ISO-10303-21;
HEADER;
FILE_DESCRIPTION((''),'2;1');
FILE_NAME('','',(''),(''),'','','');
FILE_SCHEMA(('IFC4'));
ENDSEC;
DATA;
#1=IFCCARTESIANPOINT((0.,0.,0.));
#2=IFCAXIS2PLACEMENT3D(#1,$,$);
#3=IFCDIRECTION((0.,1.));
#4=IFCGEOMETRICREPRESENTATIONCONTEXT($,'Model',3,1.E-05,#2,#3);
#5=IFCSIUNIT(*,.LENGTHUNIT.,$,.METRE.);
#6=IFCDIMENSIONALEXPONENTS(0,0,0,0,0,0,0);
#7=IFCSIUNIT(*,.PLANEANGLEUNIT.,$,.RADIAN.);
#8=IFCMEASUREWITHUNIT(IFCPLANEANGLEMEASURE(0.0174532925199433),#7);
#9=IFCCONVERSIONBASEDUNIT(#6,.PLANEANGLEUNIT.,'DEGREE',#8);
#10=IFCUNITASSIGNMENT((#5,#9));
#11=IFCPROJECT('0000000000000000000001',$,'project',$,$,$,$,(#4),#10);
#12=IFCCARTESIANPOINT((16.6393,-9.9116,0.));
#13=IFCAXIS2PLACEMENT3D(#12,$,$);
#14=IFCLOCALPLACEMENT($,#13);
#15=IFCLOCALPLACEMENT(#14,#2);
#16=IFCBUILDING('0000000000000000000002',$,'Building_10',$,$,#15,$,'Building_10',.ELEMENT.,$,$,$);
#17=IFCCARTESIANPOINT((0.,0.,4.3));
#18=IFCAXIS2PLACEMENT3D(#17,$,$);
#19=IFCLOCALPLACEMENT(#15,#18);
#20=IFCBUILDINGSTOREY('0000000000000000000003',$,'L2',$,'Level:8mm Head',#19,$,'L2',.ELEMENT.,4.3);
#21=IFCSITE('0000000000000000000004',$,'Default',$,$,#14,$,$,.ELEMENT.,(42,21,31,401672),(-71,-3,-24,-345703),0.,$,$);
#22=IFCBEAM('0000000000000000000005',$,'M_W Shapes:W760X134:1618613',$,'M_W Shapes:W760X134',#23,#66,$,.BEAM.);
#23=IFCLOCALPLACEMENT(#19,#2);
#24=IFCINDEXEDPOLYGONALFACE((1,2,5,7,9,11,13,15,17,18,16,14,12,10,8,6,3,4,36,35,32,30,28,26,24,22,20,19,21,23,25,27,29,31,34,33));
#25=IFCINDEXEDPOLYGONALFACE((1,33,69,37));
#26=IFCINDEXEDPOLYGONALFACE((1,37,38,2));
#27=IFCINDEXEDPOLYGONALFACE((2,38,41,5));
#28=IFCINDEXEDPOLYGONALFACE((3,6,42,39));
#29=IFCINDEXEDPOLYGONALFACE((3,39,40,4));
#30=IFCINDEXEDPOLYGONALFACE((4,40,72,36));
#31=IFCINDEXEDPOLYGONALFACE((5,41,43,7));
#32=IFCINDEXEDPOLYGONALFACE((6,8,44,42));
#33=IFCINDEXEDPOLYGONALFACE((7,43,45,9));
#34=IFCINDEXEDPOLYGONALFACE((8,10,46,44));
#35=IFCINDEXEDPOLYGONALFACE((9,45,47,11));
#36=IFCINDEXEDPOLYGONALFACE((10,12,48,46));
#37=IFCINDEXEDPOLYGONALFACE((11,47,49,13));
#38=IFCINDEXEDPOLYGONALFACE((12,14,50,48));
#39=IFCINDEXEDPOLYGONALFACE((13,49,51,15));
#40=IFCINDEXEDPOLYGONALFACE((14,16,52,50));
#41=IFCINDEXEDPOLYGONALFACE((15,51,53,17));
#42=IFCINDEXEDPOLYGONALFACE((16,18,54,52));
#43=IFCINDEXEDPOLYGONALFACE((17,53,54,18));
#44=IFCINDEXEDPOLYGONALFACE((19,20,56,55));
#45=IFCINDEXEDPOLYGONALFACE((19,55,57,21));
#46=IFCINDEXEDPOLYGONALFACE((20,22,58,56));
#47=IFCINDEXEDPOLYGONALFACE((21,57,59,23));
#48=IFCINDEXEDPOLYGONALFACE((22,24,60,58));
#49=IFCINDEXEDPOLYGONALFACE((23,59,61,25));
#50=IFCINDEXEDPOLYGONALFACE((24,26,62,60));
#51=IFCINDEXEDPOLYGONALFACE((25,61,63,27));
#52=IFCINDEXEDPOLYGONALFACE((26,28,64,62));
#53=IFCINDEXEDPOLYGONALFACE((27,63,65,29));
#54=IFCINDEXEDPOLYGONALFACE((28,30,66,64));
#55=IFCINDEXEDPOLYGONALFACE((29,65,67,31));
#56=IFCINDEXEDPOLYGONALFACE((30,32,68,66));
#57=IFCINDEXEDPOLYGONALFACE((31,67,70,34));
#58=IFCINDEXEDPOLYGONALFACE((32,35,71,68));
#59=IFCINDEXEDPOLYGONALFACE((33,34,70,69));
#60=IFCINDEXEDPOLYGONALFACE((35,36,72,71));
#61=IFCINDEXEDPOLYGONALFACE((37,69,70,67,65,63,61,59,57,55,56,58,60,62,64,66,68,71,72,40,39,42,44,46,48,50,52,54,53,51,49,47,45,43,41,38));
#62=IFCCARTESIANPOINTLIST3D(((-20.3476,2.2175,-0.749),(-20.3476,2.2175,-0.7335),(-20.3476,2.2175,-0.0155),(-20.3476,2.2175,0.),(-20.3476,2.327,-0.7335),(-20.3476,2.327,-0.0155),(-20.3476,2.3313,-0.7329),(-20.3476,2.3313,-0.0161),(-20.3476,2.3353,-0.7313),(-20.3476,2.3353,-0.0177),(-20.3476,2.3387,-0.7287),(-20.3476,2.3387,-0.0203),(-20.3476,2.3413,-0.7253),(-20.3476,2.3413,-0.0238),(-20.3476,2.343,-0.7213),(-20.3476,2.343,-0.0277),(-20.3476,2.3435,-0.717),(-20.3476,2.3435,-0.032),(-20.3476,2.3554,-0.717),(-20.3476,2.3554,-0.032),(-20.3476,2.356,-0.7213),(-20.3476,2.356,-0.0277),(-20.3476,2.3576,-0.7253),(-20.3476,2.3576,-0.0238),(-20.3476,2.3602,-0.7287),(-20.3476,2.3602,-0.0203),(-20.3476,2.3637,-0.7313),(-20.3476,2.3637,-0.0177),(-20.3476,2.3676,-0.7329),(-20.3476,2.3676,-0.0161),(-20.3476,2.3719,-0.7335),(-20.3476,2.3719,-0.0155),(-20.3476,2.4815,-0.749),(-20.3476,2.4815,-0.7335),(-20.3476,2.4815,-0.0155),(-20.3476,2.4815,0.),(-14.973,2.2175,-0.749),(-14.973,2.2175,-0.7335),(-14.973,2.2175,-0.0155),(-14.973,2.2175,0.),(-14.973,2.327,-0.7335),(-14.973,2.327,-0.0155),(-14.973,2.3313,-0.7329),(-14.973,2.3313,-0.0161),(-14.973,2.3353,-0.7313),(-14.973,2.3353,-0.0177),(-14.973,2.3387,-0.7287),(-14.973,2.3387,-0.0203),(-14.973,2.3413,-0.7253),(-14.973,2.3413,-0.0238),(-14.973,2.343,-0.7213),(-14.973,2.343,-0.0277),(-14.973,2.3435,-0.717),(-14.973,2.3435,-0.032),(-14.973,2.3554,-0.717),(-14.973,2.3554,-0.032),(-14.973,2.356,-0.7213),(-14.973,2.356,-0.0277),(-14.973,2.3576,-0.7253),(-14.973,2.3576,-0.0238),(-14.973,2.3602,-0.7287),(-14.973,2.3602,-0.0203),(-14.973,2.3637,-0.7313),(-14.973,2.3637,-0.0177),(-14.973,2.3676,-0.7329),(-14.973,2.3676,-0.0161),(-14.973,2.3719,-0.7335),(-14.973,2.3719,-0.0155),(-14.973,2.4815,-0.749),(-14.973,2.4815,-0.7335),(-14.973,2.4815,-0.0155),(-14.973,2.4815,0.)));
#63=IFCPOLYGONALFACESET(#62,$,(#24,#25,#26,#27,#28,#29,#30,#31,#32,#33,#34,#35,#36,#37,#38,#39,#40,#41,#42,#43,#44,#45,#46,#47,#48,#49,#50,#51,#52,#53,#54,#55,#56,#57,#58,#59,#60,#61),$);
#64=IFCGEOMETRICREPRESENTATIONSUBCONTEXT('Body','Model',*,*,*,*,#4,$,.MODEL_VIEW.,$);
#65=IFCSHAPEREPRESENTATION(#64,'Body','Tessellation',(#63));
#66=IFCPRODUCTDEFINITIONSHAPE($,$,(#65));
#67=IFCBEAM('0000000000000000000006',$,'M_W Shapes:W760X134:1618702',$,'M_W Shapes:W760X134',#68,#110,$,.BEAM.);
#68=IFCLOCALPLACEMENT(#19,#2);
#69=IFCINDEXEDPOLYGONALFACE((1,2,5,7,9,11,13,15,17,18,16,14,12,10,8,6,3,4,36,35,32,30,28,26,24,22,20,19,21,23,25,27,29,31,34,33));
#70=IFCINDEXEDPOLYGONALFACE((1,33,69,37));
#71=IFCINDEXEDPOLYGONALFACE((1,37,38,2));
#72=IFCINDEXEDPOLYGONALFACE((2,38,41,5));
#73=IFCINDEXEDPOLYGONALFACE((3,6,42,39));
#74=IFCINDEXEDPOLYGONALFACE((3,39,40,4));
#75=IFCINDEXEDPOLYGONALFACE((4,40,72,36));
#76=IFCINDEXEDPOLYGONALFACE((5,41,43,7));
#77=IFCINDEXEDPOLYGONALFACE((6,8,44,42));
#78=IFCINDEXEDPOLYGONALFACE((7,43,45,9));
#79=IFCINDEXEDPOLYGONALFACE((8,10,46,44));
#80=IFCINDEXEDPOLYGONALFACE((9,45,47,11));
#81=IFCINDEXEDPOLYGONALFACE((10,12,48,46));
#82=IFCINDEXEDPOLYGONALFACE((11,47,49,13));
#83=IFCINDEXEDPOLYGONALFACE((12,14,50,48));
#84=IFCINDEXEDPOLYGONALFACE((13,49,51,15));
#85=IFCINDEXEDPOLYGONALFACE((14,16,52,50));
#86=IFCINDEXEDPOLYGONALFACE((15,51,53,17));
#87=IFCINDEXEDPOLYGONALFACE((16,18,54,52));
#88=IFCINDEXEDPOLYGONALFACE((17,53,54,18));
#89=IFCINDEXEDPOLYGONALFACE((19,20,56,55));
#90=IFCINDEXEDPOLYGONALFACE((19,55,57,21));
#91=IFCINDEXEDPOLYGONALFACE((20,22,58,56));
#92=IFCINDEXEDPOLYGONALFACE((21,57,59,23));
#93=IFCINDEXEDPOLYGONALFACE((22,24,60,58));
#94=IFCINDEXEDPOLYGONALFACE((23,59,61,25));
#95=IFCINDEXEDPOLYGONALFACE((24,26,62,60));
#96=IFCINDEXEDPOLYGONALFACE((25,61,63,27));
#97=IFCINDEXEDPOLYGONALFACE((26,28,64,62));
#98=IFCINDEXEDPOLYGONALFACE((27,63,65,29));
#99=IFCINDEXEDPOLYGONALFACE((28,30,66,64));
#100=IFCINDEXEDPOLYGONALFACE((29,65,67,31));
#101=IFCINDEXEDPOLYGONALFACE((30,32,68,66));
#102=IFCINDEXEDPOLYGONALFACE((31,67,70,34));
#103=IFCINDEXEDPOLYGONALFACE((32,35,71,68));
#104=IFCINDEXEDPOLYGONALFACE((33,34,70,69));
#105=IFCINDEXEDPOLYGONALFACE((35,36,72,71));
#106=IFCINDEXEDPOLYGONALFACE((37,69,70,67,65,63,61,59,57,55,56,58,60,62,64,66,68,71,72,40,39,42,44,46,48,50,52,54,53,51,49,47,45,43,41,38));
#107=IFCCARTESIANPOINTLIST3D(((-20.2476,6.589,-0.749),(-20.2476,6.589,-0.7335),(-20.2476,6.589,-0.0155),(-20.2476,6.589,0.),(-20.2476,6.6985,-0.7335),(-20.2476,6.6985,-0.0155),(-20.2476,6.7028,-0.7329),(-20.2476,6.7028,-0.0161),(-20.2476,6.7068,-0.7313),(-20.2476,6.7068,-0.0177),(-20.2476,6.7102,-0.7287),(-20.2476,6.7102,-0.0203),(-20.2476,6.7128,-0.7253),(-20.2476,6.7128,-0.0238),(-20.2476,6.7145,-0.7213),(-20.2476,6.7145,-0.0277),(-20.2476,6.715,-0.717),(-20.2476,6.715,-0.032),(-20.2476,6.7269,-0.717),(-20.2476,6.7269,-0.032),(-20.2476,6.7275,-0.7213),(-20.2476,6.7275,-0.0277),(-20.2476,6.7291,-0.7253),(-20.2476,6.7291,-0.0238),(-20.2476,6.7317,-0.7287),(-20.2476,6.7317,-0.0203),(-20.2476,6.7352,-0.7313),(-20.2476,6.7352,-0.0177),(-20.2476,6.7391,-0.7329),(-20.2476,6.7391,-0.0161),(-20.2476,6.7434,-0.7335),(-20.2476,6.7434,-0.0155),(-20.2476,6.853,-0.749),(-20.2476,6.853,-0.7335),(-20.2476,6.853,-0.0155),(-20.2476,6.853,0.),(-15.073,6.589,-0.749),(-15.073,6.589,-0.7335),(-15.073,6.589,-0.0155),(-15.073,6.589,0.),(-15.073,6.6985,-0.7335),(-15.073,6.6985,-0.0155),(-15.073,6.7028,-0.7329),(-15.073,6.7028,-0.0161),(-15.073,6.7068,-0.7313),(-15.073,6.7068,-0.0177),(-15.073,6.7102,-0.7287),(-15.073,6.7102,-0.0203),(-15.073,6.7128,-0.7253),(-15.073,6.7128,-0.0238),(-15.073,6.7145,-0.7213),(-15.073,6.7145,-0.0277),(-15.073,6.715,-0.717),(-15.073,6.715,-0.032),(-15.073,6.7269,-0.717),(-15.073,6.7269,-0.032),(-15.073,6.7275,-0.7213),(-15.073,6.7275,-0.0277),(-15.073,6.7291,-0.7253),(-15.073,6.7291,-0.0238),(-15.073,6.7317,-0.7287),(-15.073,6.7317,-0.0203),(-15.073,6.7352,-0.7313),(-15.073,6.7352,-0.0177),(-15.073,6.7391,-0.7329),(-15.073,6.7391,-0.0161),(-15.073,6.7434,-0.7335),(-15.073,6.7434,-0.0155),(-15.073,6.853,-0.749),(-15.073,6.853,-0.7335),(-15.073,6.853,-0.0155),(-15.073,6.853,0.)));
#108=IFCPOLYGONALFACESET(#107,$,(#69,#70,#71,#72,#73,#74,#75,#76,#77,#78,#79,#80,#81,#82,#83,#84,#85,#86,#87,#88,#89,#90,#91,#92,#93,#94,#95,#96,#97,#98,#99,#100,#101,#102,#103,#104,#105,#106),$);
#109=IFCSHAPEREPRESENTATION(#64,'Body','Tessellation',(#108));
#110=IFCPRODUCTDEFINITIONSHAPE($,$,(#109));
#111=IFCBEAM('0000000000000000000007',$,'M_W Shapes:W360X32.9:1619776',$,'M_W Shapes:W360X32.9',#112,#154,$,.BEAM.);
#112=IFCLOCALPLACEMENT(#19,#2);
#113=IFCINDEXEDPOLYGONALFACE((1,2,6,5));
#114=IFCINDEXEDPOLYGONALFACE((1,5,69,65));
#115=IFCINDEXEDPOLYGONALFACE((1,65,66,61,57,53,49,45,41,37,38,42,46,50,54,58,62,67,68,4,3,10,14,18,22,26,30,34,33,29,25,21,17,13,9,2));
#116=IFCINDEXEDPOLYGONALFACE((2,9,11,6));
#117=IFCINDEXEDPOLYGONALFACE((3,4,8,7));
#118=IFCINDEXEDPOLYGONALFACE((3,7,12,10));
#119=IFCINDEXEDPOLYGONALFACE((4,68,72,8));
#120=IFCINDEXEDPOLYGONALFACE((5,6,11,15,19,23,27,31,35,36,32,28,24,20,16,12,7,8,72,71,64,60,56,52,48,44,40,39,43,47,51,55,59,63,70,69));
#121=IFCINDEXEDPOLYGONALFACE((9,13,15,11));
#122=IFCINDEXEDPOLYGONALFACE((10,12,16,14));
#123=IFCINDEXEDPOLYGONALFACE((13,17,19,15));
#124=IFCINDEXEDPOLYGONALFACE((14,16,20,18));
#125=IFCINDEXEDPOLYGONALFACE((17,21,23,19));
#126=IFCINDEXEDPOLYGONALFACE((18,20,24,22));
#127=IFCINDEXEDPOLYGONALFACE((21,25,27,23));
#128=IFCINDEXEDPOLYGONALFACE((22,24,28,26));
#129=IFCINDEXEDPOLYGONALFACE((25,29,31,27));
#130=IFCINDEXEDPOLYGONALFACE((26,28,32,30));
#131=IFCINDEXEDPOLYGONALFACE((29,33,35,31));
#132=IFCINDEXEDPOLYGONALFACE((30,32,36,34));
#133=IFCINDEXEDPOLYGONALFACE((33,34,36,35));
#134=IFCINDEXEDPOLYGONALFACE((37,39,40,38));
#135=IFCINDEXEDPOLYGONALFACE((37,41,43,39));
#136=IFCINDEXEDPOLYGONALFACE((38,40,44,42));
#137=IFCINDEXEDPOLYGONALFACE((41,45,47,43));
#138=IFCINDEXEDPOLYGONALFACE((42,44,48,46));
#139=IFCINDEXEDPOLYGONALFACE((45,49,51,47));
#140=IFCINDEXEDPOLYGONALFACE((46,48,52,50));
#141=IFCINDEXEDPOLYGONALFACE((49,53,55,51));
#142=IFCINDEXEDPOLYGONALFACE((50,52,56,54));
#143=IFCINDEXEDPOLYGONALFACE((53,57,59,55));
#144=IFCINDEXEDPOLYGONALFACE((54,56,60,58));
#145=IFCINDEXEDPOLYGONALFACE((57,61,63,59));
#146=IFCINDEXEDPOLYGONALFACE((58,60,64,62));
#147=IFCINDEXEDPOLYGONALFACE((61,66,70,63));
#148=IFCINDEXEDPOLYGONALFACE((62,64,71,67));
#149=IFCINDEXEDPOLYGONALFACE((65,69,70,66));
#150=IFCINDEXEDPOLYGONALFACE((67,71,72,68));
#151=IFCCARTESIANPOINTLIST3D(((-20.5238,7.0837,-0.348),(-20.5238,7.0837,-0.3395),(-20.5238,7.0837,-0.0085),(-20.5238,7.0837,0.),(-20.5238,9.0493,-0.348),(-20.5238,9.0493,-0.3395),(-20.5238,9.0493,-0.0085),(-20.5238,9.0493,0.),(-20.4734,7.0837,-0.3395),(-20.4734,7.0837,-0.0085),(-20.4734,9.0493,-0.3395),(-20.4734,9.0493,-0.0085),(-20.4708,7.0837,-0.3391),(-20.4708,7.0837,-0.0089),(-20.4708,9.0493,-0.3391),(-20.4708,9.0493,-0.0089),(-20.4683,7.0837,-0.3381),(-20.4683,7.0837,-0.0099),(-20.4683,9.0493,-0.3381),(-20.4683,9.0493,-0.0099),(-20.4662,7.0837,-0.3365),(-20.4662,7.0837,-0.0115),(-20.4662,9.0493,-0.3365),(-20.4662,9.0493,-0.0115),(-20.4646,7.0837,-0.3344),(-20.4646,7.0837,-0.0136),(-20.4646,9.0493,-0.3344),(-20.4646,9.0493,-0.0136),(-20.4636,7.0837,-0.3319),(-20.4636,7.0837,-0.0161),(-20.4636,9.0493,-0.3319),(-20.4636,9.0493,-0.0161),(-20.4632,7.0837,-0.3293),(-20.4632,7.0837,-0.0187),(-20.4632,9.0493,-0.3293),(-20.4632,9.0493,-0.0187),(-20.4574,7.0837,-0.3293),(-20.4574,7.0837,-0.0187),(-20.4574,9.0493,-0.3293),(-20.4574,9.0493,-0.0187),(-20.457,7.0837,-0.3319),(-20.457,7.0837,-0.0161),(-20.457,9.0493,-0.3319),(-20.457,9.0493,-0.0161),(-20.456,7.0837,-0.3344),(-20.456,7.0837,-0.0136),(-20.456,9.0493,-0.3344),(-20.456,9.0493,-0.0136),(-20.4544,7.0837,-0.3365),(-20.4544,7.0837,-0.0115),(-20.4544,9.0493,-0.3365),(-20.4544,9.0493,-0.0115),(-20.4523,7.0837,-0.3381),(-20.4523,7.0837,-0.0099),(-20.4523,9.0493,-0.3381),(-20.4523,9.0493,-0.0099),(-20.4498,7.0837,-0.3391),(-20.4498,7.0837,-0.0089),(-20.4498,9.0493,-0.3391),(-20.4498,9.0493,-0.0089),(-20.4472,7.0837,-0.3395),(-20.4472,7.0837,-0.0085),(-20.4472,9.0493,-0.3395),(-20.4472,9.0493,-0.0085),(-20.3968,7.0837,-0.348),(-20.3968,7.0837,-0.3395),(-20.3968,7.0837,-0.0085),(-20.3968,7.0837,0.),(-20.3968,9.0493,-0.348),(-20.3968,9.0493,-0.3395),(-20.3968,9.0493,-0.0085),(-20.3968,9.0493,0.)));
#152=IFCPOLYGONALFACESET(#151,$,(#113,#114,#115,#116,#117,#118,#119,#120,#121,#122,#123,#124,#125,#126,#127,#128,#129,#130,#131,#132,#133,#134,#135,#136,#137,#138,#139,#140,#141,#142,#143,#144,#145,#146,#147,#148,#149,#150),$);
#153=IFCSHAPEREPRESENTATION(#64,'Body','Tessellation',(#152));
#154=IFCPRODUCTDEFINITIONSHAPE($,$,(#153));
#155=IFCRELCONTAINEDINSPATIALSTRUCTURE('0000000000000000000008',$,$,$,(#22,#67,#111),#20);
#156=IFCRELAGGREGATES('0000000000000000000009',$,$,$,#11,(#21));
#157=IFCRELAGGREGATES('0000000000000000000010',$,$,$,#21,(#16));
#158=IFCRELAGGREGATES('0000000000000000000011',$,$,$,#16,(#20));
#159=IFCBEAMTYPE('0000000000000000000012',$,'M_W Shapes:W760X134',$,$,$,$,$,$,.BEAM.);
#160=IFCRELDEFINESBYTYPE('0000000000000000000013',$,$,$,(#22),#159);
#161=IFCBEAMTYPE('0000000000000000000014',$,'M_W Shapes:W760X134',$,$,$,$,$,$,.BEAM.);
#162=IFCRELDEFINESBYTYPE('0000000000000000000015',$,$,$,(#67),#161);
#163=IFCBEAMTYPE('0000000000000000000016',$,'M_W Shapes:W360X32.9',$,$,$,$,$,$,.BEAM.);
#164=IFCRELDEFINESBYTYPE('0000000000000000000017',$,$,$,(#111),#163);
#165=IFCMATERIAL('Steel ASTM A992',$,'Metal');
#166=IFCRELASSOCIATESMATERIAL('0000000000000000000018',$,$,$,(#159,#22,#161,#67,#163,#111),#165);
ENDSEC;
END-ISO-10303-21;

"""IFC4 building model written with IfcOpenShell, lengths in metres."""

from ifc_helpers import new_model, entity, si_unit, converted_unit, direction, frame, origin, place, context, subcontext, project, spatial, line, arc, indexed_curve, outline, extrude, source, transform, mapped, material, type_object, type_shapes, element, save


model = new_model("IFC4")

# Units and contexts
model_context = context("Model", 3, precision=1e-05, world=origin(), true_north=direction((0.0, 1.0)))
body_context = subcontext(model_context, "Body", "Model", "MODEL_VIEW")
ifc_project = project(units=[si_unit("LENGTHUNIT", "METRE"), converted_unit("PLANEANGLEUNIT", "DEGREE", entity("IfcPlaneAngleMeasure", 0.0174532925199433), si_unit("PLANEANGLEUNIT", "RADIAN"), dimensions=[0, 0, 0, 0, 0, 0, 0])], contexts=[model_context])

# Site, building, storey
site_placement = place(None, frame((16.6393, -9.9116, 0.0)))
site = spatial("IfcSite", under=ifc_project, at=site_placement, Name="Default", CompositionType="ELEMENT", RefLatitude=(42, 21, 31, 401672), RefLongitude=(-71, -3, -24, -345703), RefElevation=0.0)
building_placement = place(site_placement, origin())
building = spatial("IfcBuilding", under=site, at=building_placement, Name="Building_10", LongName="Building_10", CompositionType="ELEMENT")
storey_placement = place(building_placement, frame((0.0, 0.0, 4.3)))
storey = spatial("IfcBuildingStorey", under=building, at=storey_placement, Name="L2", ObjectType="Level:8mm Head", LongName="L2", CompositionType="ELEMENT", Elevation=4.3)

# Beams
ifc_material_1 = material(Name="Steel ASTM A992", Category="Metal")
beam_type_1 = type_object("IfcBeamType", Name="M_W Shapes:W760X134", PredefinedType="BEAM", material=ifc_material_1)
shared_shape_1 = source(origin(), body_context, "Body", "SweptSolid", [
    extrude(outline(indexed_curve([(-0.132, -0.359), (-0.132, -0.3745), (0.132, -0.3745), (0.132, -0.359), (0.0224, -0.359), (0.0108, -0.3542), (0.0059, -0.3425), (0.0059, 0.3425), (0.0108, 0.3542), (0.0225, 0.359), (0.132, 0.359), (0.132, 0.3745), (-0.132, 0.3745), (-0.132, 0.359), (-0.0225, 0.359), (-0.0108, 0.3542), (-0.006, 0.3425), (-0.006, -0.3425), (-0.0108, -0.3542), (-0.0225, -0.359)], segments=[line(1, 2, 3, 4, 5), arc(5, 6, 7), line(7, 8), arc(8, 9, 10), line(10, 11, 12, 13, 14, 15), arc(15, 16, 17), line(17, 18), arc(18, 19, 20), line(20, 1)], self_intersect=False)), frame((-2.6873, 0.0, 0.0), z_axis=(-1.0, 0.0, 0.0), x_axis=(0.0, -1.0, 0.0)), (0.0, 0.0, -1.0), 5.3746),
])
type_shapes(beam_type_1, [shared_shape_1])
for number, where, name in (
    (1, (-17.6603, 2.3495, -0.3745), "M_W Shapes:W760X134:1618613"),
):
    element("IfcBeam", number, at=place(storey_placement, frame(where)), inside=storey, type_object=beam_type_1, material=ifc_material_1, Name=name, ObjectType="M_W Shapes:W760X134", PredefinedType="BEAM", context=body_context, shape_type="MappedRepresentation", body=[
        mapped(shared_shape_1, transform((0.0, 0.0, 0.0), scale=1.0)),
    ])
beam_type_2 = type_object("IfcBeamType", Name="M_W Shapes:W760X134", PredefinedType="BEAM", material=ifc_material_1)
shared_shape_2 = source(origin(), body_context, "Body", "SweptSolid", [
    extrude(outline(indexed_curve([(-0.132, -0.359), (-0.132, -0.3745), (0.132, -0.3745), (0.132, -0.359), (0.0224, -0.359), (0.0108, -0.3542), (0.0059, -0.3425), (0.0059, 0.3425), (0.0108, 0.3542), (0.0225, 0.359), (0.132, 0.359), (0.132, 0.3745), (-0.132, 0.3745), (-0.132, 0.359), (-0.0225, 0.359), (-0.0108, 0.3542), (-0.006, 0.3425), (-0.006, -0.3425), (-0.0108, -0.3542), (-0.0225, -0.359)], segments=[line(1, 2, 3, 4, 5), arc(5, 6, 7), line(7, 8), arc(8, 9, 10), line(10, 11, 12, 13, 14, 15), arc(15, 16, 17), line(17, 18), arc(18, 19, 20), line(20, 1)], self_intersect=False)), frame((-2.5873, 0.0, 0.0), z_axis=(-1.0, 0.0, 0.0), x_axis=(0.0, -1.0, 0.0)), (0.0, 0.0, -1.0), 5.1746),
])
type_shapes(beam_type_2, [shared_shape_2])
beam_placement = place(storey_placement, frame((-17.6603, 6.721, -0.3745)))
element("IfcBeam", 2, at=beam_placement, inside=storey, type_object=beam_type_2, material=ifc_material_1, Name="M_W Shapes:W760X134:1618702", ObjectType="M_W Shapes:W760X134", PredefinedType="BEAM", context=body_context, shape_type="MappedRepresentation", body=[
    mapped(shared_shape_2, transform((0.0, 0.0, 0.0), scale=1.0)),
])
beam_type_3 = type_object("IfcBeamType", Name="M_W Shapes:W360X32.9", PredefinedType="BEAM", material=ifc_material_1)
shared_shape_3 = source(origin(), body_context, "Body", "SweptSolid", [
    extrude(outline(indexed_curve([(-0.0635, -0.1655), (-0.0635, -0.174), (0.0635, -0.174), (0.0635, -0.1655), (0.0131, -0.1655), (0.0059, -0.1625), (0.0029, -0.1553), (0.0029, 0.1553), (0.0059, 0.1625), (0.0131, 0.1655), (0.0635, 0.1655), (0.0635, 0.174), (-0.0635, 0.174), (-0.0635, 0.1655), (-0.0131, 0.1655), (-0.0059, 0.1625), (-0.0029, 0.1553), (-0.0029, -0.1553), (-0.0059, -0.1625), (-0.0131, -0.1655)], segments=[line(1, 2, 3, 4, 5), arc(5, 6, 7), line(7, 8), arc(8, 9, 10), line(10, 11, 12, 13, 14, 15), arc(15, 16, 17), line(17, 18), arc(18, 19, 20), line(20, 1)], self_intersect=False)), frame((-0.9828, 0.0, 0.0), z_axis=(-1.0, 0.0, 0.0), x_axis=(0.0, -1.0, 0.0)), (0.0, 0.0, -1.0), 1.9656),
])
type_shapes(beam_type_3, [shared_shape_3])
for number, where, z_axis, x_axis, name in (
    (3, (-20.4603, 8.0665, -0.174), (0.0, 0.0, 1.0), (0.0, 1.0, 0.0), "M_W Shapes:W360X32.9:1619776"),
):
    element("IfcBeam", number, at=place(storey_placement, frame(where, z_axis=z_axis, x_axis=x_axis)), inside=storey, type_object=beam_type_3, material=ifc_material_1, Name=name, ObjectType="M_W Shapes:W360X32.9", PredefinedType="BEAM", context=body_context, shape_type="MappedRepresentation", body=[
        mapped(shared_shape_3, transform((0.0, 0.0, 0.0), scale=1.0)),
    ])

save(model, "model.ifc")
